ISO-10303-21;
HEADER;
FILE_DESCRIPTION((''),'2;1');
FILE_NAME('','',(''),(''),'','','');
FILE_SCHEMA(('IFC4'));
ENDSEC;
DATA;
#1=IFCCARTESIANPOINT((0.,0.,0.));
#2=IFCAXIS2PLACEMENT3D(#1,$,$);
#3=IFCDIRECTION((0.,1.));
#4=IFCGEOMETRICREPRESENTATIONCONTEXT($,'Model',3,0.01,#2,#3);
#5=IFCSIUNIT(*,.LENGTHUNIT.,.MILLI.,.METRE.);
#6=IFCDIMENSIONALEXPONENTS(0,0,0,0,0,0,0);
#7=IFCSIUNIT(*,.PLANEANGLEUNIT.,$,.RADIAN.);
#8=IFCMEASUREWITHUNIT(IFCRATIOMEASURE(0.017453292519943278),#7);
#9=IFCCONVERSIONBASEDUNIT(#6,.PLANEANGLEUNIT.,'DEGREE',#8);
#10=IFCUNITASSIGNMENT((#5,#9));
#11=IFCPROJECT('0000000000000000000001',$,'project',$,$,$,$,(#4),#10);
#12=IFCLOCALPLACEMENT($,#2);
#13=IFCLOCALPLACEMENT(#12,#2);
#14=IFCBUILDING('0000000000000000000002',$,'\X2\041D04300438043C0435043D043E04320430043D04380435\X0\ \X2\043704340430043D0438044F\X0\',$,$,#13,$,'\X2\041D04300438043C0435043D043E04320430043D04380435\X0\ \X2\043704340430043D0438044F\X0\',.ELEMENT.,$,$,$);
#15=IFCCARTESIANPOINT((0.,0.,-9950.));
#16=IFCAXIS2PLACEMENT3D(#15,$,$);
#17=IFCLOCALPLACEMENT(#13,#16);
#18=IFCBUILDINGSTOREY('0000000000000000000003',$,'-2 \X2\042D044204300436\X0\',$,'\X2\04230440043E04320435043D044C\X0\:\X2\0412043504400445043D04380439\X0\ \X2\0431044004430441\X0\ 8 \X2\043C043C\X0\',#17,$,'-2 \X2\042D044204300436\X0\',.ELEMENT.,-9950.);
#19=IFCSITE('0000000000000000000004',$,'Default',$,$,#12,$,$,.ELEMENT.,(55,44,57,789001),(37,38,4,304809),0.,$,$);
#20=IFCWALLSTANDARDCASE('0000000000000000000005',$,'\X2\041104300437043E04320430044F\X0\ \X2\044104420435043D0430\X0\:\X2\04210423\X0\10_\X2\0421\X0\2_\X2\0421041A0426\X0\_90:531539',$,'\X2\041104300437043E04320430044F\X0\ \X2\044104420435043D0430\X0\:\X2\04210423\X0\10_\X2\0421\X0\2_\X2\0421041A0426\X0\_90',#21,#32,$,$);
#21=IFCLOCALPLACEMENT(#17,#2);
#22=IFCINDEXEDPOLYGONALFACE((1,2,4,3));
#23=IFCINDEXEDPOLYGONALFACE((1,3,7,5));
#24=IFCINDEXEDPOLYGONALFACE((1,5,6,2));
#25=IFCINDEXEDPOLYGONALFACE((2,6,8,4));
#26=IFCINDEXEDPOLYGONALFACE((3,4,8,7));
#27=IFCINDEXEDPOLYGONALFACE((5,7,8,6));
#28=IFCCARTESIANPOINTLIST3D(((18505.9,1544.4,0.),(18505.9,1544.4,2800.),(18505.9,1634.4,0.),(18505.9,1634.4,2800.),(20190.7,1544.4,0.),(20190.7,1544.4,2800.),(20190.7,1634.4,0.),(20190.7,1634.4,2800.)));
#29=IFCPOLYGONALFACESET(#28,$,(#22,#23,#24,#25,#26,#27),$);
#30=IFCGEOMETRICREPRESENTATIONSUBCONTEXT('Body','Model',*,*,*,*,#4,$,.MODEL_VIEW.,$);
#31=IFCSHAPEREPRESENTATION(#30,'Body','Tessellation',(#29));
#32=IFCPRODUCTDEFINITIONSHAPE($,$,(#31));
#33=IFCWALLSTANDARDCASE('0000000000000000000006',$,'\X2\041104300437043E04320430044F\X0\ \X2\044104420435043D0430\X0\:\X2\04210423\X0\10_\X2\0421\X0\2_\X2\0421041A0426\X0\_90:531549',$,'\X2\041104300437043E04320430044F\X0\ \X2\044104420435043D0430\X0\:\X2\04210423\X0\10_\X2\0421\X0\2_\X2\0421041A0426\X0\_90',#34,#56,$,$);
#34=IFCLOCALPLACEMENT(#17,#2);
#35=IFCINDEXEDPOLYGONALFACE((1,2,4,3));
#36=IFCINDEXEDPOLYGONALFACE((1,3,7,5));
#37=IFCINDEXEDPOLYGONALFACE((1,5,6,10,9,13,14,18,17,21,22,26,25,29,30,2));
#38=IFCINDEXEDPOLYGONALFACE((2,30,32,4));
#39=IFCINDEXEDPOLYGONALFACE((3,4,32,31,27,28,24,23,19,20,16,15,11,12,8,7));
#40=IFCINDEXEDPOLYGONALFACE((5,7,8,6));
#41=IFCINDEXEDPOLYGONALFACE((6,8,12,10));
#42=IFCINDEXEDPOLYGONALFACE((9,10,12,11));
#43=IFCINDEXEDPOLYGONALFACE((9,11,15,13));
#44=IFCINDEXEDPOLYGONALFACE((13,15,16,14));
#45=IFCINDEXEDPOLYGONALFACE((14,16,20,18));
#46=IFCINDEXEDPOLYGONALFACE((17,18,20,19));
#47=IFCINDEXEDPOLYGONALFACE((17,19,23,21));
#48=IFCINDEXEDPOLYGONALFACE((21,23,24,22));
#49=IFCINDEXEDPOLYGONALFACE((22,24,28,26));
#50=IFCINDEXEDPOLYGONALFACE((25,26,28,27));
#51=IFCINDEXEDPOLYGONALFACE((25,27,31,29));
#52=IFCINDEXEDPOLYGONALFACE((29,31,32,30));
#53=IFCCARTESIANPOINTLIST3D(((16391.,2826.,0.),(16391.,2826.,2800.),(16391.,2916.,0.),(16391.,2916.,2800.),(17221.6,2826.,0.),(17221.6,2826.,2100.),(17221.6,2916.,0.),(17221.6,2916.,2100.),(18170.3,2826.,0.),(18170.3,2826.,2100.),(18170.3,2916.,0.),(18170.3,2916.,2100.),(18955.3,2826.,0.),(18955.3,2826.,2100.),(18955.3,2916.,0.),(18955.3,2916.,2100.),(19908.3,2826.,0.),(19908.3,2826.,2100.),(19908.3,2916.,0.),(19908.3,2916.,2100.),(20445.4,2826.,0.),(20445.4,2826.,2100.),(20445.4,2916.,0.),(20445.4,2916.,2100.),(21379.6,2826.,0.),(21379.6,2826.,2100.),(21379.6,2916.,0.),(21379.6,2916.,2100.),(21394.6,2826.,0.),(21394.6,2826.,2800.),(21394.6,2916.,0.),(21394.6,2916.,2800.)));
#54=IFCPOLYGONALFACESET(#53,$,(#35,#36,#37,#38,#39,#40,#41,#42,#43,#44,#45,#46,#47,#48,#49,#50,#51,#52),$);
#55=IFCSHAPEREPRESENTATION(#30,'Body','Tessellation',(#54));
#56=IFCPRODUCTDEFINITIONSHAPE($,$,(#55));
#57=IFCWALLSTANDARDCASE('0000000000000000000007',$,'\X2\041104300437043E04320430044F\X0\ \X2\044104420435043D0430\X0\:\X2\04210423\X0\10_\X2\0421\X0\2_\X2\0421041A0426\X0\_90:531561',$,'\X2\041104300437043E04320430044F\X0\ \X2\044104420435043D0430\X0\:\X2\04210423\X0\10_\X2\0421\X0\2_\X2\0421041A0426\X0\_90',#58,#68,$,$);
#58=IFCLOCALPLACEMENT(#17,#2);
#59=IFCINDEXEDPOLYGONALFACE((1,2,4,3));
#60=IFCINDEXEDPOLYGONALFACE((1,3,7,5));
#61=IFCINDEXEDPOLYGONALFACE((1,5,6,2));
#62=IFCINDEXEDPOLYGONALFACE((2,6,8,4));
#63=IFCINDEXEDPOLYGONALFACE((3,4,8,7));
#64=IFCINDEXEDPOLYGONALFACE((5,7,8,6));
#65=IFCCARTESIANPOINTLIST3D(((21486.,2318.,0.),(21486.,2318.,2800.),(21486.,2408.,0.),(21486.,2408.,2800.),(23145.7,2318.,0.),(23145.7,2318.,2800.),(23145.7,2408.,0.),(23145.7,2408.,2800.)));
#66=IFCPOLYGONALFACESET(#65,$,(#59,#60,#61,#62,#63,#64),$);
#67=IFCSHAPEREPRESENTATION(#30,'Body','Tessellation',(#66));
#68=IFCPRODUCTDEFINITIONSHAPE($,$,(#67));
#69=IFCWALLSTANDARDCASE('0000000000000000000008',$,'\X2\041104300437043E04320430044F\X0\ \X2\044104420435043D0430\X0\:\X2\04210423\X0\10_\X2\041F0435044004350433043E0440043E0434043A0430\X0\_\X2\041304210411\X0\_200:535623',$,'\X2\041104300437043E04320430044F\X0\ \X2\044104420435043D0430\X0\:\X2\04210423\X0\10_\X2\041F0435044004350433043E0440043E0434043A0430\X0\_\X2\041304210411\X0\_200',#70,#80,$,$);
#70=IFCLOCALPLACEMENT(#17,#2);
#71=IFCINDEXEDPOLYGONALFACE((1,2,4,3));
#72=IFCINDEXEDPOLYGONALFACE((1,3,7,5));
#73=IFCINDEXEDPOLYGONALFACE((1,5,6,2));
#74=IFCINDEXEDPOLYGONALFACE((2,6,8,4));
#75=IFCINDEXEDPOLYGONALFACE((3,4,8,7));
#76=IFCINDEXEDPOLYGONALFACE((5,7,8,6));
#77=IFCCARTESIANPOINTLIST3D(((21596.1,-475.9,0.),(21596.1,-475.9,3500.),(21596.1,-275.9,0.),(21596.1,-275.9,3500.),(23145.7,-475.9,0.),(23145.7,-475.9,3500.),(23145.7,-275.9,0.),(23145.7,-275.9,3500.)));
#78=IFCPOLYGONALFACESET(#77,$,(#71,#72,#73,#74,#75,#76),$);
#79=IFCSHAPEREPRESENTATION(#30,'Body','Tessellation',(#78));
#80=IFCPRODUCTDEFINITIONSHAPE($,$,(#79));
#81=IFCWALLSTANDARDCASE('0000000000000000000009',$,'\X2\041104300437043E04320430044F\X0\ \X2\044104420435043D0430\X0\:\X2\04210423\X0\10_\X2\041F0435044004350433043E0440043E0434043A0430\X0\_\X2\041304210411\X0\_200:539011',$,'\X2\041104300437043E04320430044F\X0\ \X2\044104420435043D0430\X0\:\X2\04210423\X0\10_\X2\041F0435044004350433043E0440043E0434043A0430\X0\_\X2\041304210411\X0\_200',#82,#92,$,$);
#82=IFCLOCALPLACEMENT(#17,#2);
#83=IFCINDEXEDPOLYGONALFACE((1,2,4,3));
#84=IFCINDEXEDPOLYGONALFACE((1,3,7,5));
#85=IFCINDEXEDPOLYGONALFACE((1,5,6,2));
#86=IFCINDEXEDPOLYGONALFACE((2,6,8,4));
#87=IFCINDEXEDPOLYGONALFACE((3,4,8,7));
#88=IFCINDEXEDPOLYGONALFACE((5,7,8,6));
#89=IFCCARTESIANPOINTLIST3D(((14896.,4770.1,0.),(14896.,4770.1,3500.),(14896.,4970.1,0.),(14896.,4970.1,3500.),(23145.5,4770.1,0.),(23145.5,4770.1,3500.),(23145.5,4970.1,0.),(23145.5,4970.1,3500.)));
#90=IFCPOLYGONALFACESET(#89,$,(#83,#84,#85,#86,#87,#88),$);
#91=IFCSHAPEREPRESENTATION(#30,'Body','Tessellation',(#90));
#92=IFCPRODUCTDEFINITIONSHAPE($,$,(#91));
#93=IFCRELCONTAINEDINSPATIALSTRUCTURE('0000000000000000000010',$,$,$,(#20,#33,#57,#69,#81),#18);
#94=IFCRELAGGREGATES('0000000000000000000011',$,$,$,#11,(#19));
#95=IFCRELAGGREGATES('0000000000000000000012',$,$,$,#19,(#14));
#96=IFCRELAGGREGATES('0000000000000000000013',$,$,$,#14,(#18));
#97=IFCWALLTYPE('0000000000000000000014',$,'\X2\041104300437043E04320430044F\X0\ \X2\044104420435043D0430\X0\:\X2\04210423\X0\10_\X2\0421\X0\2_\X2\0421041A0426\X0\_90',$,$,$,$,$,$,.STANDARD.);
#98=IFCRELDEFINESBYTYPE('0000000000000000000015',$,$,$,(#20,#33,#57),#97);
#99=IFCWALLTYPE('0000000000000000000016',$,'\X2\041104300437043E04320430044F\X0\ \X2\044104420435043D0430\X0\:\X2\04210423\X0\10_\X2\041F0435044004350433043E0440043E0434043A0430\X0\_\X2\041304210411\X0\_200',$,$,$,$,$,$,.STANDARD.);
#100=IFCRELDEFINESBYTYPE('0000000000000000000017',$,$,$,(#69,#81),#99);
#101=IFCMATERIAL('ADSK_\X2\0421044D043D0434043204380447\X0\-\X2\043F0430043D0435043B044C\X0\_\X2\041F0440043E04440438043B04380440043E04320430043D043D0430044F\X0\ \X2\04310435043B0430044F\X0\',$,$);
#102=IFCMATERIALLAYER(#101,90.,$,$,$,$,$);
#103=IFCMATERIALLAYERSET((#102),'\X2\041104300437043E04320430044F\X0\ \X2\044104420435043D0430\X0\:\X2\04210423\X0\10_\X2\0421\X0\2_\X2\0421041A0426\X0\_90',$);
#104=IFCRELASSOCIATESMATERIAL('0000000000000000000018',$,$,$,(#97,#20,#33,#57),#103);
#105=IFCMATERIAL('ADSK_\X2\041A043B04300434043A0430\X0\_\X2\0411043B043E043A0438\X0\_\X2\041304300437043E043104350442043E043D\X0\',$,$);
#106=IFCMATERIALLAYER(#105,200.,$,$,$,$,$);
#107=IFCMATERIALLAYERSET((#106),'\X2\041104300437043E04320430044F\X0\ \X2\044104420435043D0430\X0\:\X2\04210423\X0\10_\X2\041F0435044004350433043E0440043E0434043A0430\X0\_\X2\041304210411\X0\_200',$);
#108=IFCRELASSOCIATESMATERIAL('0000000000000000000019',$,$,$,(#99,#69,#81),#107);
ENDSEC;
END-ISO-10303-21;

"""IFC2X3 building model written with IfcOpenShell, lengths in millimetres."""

from ifc_helpers import new_model, entity, si_unit, converted_unit, direction, frame, frame_2d, origin, place, context, subcontext, project, spatial, rectangle, extrude, material, layer, layer_set, layer_usage, type_object, element, save


model = new_model("IFC2X3")

# Units and contexts
model_context = context("Model", 3, precision=0.01, world=origin(), true_north=direction((0.0, 1.0)))
body_context = subcontext(model_context, "Body", "Model", "MODEL_VIEW")
ifc_project = project(units=[si_unit("LENGTHUNIT", "METRE", prefix="MILLI"), converted_unit("PLANEANGLEUNIT", "DEGREE", entity("IfcRatioMeasure", 0.017453292519943278), si_unit("PLANEANGLEUNIT", "RADIAN"), dimensions=[0, 0, 0, 0, 0, 0, 0])], contexts=[model_context])

# Site, building, storey
site_placement = place(None, origin())
site = spatial("IfcSite", under=ifc_project, at=site_placement, Name="Default", CompositionType="ELEMENT", RefLatitude=(55, 44, 57, 789001), RefLongitude=(37, 38, 4, 304809), RefElevation=0.0)
building_placement = place(site_placement, origin())
building = spatial("IfcBuilding", under=site, at=building_placement, Name="Наименование здания", LongName="Наименование здания", CompositionType="ELEMENT")
storey_placement = place(building_placement, frame((0.0, 0.0, -9950.0)))
storey = spatial("IfcBuildingStorey", under=building, at=storey_placement, Name="-2 Этаж", ObjectType="Уровень:Верхний брус 8 мм", LongName="-2 Этаж", CompositionType="ELEMENT", Elevation=-9950.0)

# Shared definitions
ifc_material_1 = material(Name="ADSK_Сэндвич-панель_Профилированная белая")
ifc_layer_1 = layer(ifc_material_1, 90.0)
ifc_layer_set_1 = layer_set([ifc_layer_1], Name="Базовая стена:СУ10_С2_СКЦ_90")
ifc_layer_usage_1 = layer_usage(ifc_layer_set_1, "AXIS2", "NEGATIVE", 45.0)
wall_type_1 = type_object("IfcWallType", Name="Базовая стена:СУ10_С2_СКЦ_90", PredefinedType="STANDARD", material=ifc_layer_set_1)

# Wall
wall_1_placement = place(storey_placement, frame((20190.7, 1589.4, 0.0), z_axis=(0.0, 0.0, 1.0), x_axis=(-1.0, 0.0, 0.0)))
element("IfcWallStandardCase", 1, at=wall_1_placement, inside=storey, type_object=wall_type_1, material=ifc_layer_usage_1, Name="Базовая стена:СУ10_С2_СКЦ_90:531539", ObjectType="Базовая стена:СУ10_С2_СКЦ_90", context=body_context, shape_type="SweptSolid", body=[
    extrude(rectangle(XDim=1684.8, YDim=90.0, at=frame_2d((842.4, 0.0), x_axis=(-1.0, 0.0))), origin(), (0.0, 0.0, 1.0), 2800.0),
])

# Wall, openings
wall_2_placement = place(storey_placement, frame((21394.6, 2871.0, 0.0), z_axis=(0.0, 0.0, 1.0), x_axis=(-1.0, 0.0, 0.0)))
wall_2 = element("IfcWallStandardCase", 2, at=wall_2_placement, inside=storey, type_object=wall_type_1, material=ifc_layer_usage_1, Name="Базовая стена:СУ10_С2_СКЦ_90:531549", ObjectType="Базовая стена:СУ10_С2_СКЦ_90", context=body_context, shape_type="SweptSolid", body=[
    extrude(rectangle(XDim=5003.7, YDim=90.0, at=frame_2d((2501.8, 0.0), x_axis=(1.0, 0.0))), origin(), (0.0, 0.0, 1.0), 2800.0),
])
opening_1_placement = place(wall_2_placement, origin())
element("IfcOpeningElement", 3, at=opening_1_placement, cuts=wall_2, ObjectType="Opening", context=body_context, shape_type="SweptSolid", body=[
    extrude(rectangle(XDim=2100.0, YDim=934.3, at=frame_2d((0.0, 0.0), x_axis=(1.0, 0.0))), frame((482.1, -45.0, 1050.0), z_axis=(0.0, 1.0, 0.0), x_axis=(0.0, 0.0, -1.0)), (0.0, 0.0, 1.0), 90.0),
])
opening_2_placement = place(wall_2_placement, origin())
element("IfcOpeningElement", 4, at=opening_2_placement, cuts=wall_2, ObjectType="Opening", context=body_context, shape_type="SweptSolid", body=[
    extrude(rectangle(XDim=2100.0, YDim=953.0, at=frame_2d((0.0, 0.0), x_axis=(1.0, 0.0))), frame((1962.8, -45.0, 1050.0), z_axis=(0.0, 1.0, 0.0), x_axis=(0.0, 0.0, -1.0)), (0.0, 0.0, 1.0), 90.0),
])
opening_3_placement = place(wall_2_placement, origin())
element("IfcOpeningElement", 5, at=opening_3_placement, cuts=wall_2, ObjectType="Opening", context=body_context, shape_type="SweptSolid", body=[
    extrude(rectangle(XDim=2100.0, YDim=948.8, at=frame_2d((0.0, 0.0), x_axis=(1.0, 0.0))), frame((3698.7, -45.0, 1050.0), z_axis=(0.0, 1.0, 0.0), x_axis=(0.0, 0.0, -1.0)), (0.0, 0.0, 1.0), 90.0),
])

# Walls
wall_3_placement = place(storey_placement, frame((23145.7, 2363.0, 0.0), z_axis=(0.0, 0.0, 1.0), x_axis=(-1.0, 0.0, 0.0)))
element("IfcWallStandardCase", 6, at=wall_3_placement, inside=storey, type_object=wall_type_1, material=ifc_layer_usage_1, Name="Базовая стена:СУ10_С2_СКЦ_90:531561", ObjectType="Базовая стена:СУ10_С2_СКЦ_90", context=body_context, shape_type="SweptSolid", body=[
    extrude(rectangle(XDim=1659.7, YDim=90.0, at=frame_2d((829.8, 0.0), x_axis=(-1.0, 0.0))), origin(), (0.0, 0.0, 1.0), 2800.0),
])
ifc_material_2 = material(Name="ADSK_Кладка_Блоки_Газобетон")
ifc_layer_2 = layer(ifc_material_2, 200.0)
ifc_layer_set_2 = layer_set([ifc_layer_2], Name="Базовая стена:СУ10_Перегородка_ГСБ_200")
ifc_layer_usage_2 = layer_usage(ifc_layer_set_2, "AXIS2", "NEGATIVE", 100.0)
wall_type_2 = type_object("IfcWallType", Name="Базовая стена:СУ10_Перегородка_ГСБ_200", PredefinedType="STANDARD", material=ifc_layer_set_2)
wall_4_placement = place(storey_placement, frame((23145.7, -375.9, 0.0), z_axis=(0.0, 0.0, 1.0), x_axis=(-1.0, 0.0, 0.0)))
element("IfcWallStandardCase", 7, at=wall_4_placement, inside=storey, type_object=wall_type_2, material=ifc_layer_usage_2, Name="Базовая стена:СУ10_Перегородка_ГСБ_200:535623", ObjectType="Базовая стена:СУ10_Перегородка_ГСБ_200", context=body_context, shape_type="SweptSolid", body=[
    extrude(rectangle(XDim=1549.6, YDim=200.0, at=frame_2d((774.8, 0.0), x_axis=(-1.0, 0.0))), origin(), (0.0, 0.0, 1.0), 3500.0),
])
wall_5_placement = place(storey_placement, frame((23145.5, 4870.1, 0.0), z_axis=(0.0, 0.0, 1.0), x_axis=(-1.0, 0.0, 0.0)))
element("IfcWallStandardCase", 8, at=wall_5_placement, inside=storey, type_object=wall_type_2, material=ifc_layer_usage_2, Name="Базовая стена:СУ10_Перегородка_ГСБ_200:539011", ObjectType="Базовая стена:СУ10_Перегородка_ГСБ_200", context=body_context, shape_type="SweptSolid", body=[
    extrude(rectangle(XDim=8249.5, YDim=200.0, at=frame_2d((4124.8, 0.0), x_axis=(-1.0, 0.0))), origin(), (0.0, 0.0, 1.0), 3500.0),
])

save(model, "model.ifc")
